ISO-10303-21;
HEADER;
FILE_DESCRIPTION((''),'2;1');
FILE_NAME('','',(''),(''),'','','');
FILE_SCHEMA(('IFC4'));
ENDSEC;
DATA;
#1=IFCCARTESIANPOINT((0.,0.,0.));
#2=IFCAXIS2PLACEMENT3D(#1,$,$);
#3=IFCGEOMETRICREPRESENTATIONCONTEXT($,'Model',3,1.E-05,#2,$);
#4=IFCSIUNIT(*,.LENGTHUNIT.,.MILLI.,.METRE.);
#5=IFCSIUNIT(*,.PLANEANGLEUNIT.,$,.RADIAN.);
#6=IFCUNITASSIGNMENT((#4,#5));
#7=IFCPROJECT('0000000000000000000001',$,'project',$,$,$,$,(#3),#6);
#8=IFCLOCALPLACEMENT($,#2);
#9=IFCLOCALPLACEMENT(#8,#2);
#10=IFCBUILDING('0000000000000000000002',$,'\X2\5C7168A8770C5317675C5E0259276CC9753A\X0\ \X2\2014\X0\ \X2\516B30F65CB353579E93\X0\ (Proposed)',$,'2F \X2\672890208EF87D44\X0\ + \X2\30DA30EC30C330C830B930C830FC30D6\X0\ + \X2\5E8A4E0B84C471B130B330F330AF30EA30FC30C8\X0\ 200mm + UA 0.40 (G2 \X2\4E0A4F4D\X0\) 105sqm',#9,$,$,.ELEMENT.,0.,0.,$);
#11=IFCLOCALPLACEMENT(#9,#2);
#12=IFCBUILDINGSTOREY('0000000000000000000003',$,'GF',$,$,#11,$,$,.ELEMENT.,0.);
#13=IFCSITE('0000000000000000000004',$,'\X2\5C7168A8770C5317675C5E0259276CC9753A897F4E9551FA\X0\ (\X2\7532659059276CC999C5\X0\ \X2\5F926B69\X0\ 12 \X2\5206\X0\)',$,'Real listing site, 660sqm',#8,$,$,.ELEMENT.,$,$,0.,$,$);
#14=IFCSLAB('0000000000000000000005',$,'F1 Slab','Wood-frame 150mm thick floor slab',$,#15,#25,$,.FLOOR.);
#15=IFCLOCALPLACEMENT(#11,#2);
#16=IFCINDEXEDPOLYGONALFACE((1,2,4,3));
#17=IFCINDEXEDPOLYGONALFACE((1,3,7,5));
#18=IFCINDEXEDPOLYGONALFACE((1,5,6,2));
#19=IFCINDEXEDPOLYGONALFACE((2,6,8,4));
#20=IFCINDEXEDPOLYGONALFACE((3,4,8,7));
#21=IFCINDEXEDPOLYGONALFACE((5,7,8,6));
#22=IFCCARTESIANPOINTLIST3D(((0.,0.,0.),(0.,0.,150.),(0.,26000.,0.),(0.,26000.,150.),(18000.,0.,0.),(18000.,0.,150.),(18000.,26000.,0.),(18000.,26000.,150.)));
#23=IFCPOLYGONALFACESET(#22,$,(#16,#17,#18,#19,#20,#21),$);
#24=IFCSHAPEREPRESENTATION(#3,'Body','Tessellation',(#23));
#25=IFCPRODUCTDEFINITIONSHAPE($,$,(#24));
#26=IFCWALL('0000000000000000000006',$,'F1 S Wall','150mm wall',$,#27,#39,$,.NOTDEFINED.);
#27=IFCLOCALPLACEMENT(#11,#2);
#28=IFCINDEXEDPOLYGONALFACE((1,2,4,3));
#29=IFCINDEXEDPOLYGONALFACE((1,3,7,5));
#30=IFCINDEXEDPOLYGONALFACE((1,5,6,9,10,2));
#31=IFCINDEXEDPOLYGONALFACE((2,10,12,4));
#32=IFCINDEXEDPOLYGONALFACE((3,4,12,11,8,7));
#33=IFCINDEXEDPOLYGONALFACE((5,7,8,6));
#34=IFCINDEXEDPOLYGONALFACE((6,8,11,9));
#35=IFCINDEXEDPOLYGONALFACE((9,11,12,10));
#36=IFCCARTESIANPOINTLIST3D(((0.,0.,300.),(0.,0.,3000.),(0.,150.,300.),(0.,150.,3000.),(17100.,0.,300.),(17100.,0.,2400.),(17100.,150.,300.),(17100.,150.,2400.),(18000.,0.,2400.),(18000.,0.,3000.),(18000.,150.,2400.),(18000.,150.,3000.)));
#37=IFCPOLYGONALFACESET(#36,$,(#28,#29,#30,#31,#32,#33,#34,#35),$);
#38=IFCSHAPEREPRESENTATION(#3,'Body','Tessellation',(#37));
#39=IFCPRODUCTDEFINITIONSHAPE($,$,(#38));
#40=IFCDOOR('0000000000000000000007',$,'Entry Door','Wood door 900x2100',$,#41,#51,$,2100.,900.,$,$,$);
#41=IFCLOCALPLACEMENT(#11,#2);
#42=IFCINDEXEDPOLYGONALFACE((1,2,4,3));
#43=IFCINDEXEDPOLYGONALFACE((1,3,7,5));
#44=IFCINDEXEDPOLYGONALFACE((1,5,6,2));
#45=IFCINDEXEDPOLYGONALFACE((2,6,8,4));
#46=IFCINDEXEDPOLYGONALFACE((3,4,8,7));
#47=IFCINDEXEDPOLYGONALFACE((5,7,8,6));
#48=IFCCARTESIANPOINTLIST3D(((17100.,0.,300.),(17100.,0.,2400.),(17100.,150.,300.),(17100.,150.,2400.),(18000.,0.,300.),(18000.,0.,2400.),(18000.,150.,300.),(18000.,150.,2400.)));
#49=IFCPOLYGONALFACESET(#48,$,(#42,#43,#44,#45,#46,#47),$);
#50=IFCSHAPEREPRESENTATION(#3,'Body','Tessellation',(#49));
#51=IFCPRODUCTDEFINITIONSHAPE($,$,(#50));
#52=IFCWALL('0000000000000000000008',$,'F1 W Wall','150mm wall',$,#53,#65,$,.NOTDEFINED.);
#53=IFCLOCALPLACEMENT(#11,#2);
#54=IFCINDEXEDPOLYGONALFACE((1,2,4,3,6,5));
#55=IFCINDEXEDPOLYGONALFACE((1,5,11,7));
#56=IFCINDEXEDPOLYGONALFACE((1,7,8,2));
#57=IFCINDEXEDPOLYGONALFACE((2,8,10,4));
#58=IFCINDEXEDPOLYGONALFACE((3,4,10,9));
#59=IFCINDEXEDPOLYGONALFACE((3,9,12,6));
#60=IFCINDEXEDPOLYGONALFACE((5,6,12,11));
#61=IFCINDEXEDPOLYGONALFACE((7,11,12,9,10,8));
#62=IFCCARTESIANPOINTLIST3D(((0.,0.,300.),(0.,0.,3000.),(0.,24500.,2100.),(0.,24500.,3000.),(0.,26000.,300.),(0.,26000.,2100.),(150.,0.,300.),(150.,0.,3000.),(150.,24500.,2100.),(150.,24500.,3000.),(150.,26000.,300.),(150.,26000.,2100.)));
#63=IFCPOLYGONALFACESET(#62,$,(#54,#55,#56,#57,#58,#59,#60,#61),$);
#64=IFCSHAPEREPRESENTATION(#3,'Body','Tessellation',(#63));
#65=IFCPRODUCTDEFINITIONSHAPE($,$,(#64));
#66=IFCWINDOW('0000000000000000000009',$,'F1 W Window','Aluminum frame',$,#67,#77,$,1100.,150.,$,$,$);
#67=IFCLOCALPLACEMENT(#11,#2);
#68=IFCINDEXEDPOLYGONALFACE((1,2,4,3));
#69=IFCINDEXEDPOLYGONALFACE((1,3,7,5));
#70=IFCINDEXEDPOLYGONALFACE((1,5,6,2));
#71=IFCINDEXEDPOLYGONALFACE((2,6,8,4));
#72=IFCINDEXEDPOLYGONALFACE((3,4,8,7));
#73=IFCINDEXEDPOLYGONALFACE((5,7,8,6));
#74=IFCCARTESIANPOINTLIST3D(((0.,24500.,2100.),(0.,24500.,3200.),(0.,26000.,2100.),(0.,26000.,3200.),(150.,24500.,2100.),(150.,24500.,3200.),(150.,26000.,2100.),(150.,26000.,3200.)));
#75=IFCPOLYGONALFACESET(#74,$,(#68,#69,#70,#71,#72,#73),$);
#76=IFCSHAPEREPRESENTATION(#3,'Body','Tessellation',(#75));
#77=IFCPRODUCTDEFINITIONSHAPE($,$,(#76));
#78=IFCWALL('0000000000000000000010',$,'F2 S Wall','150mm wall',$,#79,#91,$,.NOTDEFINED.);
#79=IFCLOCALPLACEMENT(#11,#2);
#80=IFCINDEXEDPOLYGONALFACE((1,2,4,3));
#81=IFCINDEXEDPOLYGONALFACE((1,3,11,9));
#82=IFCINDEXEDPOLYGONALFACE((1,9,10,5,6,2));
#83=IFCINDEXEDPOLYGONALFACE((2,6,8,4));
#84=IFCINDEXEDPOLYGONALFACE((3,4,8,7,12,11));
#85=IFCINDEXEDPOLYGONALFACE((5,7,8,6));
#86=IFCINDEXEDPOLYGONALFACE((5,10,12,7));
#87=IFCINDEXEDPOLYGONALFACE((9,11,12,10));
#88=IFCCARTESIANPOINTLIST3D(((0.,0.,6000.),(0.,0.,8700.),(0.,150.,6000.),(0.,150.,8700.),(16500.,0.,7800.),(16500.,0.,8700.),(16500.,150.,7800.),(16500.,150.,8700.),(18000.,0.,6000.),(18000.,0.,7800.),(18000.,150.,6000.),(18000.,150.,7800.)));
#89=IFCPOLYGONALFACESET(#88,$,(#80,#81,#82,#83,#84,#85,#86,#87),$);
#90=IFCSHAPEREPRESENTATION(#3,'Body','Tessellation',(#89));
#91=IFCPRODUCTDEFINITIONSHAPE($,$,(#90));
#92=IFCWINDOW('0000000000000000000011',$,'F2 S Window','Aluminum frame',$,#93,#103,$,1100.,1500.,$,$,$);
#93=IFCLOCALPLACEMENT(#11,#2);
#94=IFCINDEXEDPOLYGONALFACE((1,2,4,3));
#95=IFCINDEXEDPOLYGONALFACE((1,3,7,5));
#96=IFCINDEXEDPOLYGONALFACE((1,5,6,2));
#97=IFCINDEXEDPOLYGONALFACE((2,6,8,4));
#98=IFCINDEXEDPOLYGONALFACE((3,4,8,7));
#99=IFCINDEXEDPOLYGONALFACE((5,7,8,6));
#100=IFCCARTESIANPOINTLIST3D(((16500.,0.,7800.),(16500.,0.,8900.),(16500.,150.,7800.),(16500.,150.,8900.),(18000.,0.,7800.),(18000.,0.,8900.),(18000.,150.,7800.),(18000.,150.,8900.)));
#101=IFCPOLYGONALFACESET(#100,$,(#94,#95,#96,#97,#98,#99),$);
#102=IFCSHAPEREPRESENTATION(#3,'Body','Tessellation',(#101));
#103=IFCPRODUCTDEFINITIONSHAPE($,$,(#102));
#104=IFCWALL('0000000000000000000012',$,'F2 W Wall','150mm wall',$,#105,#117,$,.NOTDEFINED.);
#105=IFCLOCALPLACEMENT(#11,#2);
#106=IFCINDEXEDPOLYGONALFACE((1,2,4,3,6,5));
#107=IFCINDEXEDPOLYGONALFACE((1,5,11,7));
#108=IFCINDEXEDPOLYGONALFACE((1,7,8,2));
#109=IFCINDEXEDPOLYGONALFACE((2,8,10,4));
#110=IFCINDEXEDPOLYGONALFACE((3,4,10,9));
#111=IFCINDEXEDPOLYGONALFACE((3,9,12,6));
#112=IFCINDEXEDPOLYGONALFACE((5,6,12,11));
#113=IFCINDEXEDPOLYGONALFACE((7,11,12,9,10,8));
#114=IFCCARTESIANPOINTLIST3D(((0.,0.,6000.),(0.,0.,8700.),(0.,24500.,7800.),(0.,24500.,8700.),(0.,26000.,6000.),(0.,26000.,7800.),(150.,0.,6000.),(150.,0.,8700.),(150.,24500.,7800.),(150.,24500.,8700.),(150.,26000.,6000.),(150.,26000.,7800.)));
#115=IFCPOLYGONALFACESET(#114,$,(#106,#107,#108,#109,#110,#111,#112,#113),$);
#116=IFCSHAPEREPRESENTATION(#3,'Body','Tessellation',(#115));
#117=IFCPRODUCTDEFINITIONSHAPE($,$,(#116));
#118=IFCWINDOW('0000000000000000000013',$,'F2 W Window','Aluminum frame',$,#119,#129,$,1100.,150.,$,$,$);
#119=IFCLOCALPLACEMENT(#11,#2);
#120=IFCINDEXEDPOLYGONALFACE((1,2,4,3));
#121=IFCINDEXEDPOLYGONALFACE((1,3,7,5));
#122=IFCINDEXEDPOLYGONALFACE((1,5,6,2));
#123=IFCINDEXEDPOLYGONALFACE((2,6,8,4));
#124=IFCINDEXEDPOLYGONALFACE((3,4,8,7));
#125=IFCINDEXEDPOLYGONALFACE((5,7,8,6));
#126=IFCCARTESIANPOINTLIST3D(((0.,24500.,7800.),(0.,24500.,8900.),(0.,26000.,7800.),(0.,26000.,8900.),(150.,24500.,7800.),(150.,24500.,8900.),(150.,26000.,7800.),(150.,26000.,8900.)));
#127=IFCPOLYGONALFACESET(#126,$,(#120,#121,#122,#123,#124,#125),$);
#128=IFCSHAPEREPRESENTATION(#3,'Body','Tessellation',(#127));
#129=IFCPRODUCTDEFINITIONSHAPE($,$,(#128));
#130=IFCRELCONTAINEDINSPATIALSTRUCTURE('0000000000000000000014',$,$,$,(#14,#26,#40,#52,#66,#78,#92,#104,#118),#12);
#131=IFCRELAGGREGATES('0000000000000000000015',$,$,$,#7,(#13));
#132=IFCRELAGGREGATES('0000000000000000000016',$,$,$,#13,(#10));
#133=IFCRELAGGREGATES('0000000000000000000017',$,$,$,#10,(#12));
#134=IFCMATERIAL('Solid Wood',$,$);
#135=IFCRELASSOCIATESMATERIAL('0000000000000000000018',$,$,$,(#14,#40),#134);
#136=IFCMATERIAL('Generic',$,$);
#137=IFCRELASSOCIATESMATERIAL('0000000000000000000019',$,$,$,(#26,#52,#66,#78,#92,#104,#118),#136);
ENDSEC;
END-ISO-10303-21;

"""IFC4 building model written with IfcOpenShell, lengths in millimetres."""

from ifc_helpers import new_model, si_unit, frame, frame_2d, origin, place, context, project, spatial, rectangle, extrude, material, element, fill, save


model = new_model("IFC4")

# Units and contexts
model_context = context("Model", 3, precision=1e-05, world=origin())
ifc_project = project(units=[si_unit("LENGTHUNIT", "METRE", prefix="MILLI"), si_unit("PLANEANGLEUNIT", "RADIAN")], contexts=[model_context])

# Site, building, storey
site_placement = place(None, origin())
site = spatial("IfcSite", under=ifc_project, at=site_placement, Name="山梨県北杜市大泉町西井出 (甲斐大泉駅 徒歩 12 分)", ObjectType="Real listing site, 660sqm", CompositionType="ELEMENT", RefElevation=0.0)
building_placement = place(site_placement, origin())
building = spatial("IfcBuilding", under=site, at=building_placement, Name="山梨県北杜市大泉町 — 八ヶ岳南麓 (Proposed)", ObjectType="2F 木造軸組 + ペレットストーブ + 床下蓄熱コンクリート 200mm + UA 0.40 (G2 上位) 105sqm", CompositionType="ELEMENT", ElevationOfRefHeight=0.0, ElevationOfTerrain=0.0)
storey_placement = place(building_placement, origin())
storey = spatial("IfcBuildingStorey", under=building, at=storey_placement, Name="GF", CompositionType="ELEMENT", Elevation=0.0)

# Slab
ifc_material_1 = material(Name="Solid Wood")
slab_1_placement = place(storey_placement, origin())
element("IfcSlab", 1, at=slab_1_placement, inside=storey, material=ifc_material_1, Name="F1 Slab", Description="Wood-frame 150mm thick floor slab", PredefinedType="FLOOR", context=model_context, shape_type="SweptSolid", body=[
    extrude(rectangle(XDim=18000.0, YDim=26000.0, at=frame_2d((9000.0, 13000.0))), origin(), (0.0, 0.0, 1.0), 150.0),
])

# Shared definitions
ifc_material_2 = material(Name="Generic")

# Wall, opening, door
wall_1_placement = place(storey_placement, frame((0.0, 0.0, 150.0)))
wall_1 = element("IfcWall", 2, at=wall_1_placement, inside=storey, material=ifc_material_2, Name="F1 S Wall", Description="150mm wall", PredefinedType="NOTDEFINED", context=model_context, shape_type="SweptSolid", body=[
    extrude(rectangle(XDim=18000.0, YDim=150.0, at=frame_2d((9000.0, 75.0))), frame((0.0, 0.0, 150.0)), (0.0, 0.0, 1.0), 2700.0),
])
opening_1_placement = place(storey_placement, frame((8550.0, 0.0, 150.0)))
opening_1 = element("IfcOpeningElement", 3, at=opening_1_placement, cuts=wall_1, PredefinedType="NOTDEFINED", context=model_context, shape_type="SweptSolid", body=[
    extrude(rectangle(XDim=900.0, YDim=150.0, at=frame_2d((450.0, 75.0))), frame((8550.0, 0.0, 150.0)), (0.0, 0.0, 1.0), 2100.0),
])
door_placement = place(storey_placement, frame((8550.0, 0.0, 150.0)))
door = element("IfcDoor", 4, at=door_placement, inside=storey, material=ifc_material_1, Name="Entry Door", Description="Wood door 900x2100", OverallHeight=2100.0, OverallWidth=900.0, context=model_context, shape_type="SweptSolid", body=[
    extrude(rectangle(XDim=900.0, YDim=150.0, at=frame_2d((450.0, 75.0))), frame((8550.0, 0.0, 150.0)), (0.0, 0.0, 1.0), 2100.0),
])
fill(opening_1, door)

# Walls, openings, windows
wall_2_placement = place(storey_placement, frame((0.0, 0.0, 150.0)))
wall_2 = element("IfcWall", 5, at=wall_2_placement, inside=storey, material=ifc_material_2, Name="F1 W Wall", Description="150mm wall", PredefinedType="NOTDEFINED", context=model_context, shape_type="SweptSolid", body=[
    extrude(rectangle(XDim=150.0, YDim=26000.0, at=frame_2d((75.0, 13000.0))), frame((0.0, 0.0, 150.0)), (0.0, 0.0, 1.0), 2700.0),
])
opening_2_placement = place(storey_placement, frame((0.0, 12250.0, 1050.0)))
opening_2 = element("IfcOpeningElement", 6, at=opening_2_placement, cuts=wall_2, PredefinedType="NOTDEFINED", context=model_context, shape_type="SweptSolid", body=[
    extrude(rectangle(XDim=150.0, YDim=1500.0, at=frame_2d((75.0, 750.0))), frame((0.0, 12250.0, 1050.0)), (0.0, 0.0, 1.0), 1100.0),
])
window_1_placement = place(storey_placement, frame((0.0, 12250.0, 1050.0)))
window_1 = element("IfcWindow", 7, at=window_1_placement, inside=storey, material=ifc_material_2, Name="F1 W Window", Description="Aluminum frame", OverallHeight=1100.0, OverallWidth=150.0, context=model_context, shape_type="SweptSolid", body=[
    extrude(rectangle(XDim=150.0, YDim=1500.0, at=frame_2d((75.0, 750.0))), frame((0.0, 12250.0, 1050.0)), (0.0, 0.0, 1.0), 1100.0),
])
fill(opening_2, window_1)
wall_3_placement = place(storey_placement, frame((0.0, 0.0, 3000.0)))
wall_3 = element("IfcWall", 8, at=wall_3_placement, inside=storey, material=ifc_material_2, Name="F2 S Wall", Description="150mm wall", PredefinedType="NOTDEFINED", context=model_context, shape_type="SweptSolid", body=[
    extrude(rectangle(XDim=18000.0, YDim=150.0, at=frame_2d((9000.0, 75.0))), frame((0.0, 0.0, 3000.0)), (0.0, 0.0, 1.0), 2700.0),
])
opening_3_placement = place(storey_placement, frame((8250.0, 0.0, 3900.0)))
opening_3 = element("IfcOpeningElement", 9, at=opening_3_placement, cuts=wall_3, PredefinedType="NOTDEFINED", context=model_context, shape_type="SweptSolid", body=[
    extrude(rectangle(XDim=1500.0, YDim=150.0, at=frame_2d((750.0, 75.0))), frame((8250.0, 0.0, 3900.0)), (0.0, 0.0, 1.0), 1100.0),
])
window_2_placement = place(storey_placement, frame((8250.0, 0.0, 3900.0)))
window_2 = element("IfcWindow", 10, at=window_2_placement, inside=storey, material=ifc_material_2, Name="F2 S Window", Description="Aluminum frame", OverallHeight=1100.0, OverallWidth=1500.0, context=model_context, shape_type="SweptSolid", body=[
    extrude(rectangle(XDim=1500.0, YDim=150.0, at=frame_2d((750.0, 75.0))), frame((8250.0, 0.0, 3900.0)), (0.0, 0.0, 1.0), 1100.0),
])
fill(opening_3, window_2)
wall_4_placement = place(storey_placement, frame((0.0, 0.0, 3000.0)))
wall_4 = element("IfcWall", 11, at=wall_4_placement, inside=storey, material=ifc_material_2, Name="F2 W Wall", Description="150mm wall", PredefinedType="NOTDEFINED", context=model_context, shape_type="SweptSolid", body=[
    extrude(rectangle(XDim=150.0, YDim=26000.0, at=frame_2d((75.0, 13000.0))), frame((0.0, 0.0, 3000.0)), (0.0, 0.0, 1.0), 2700.0),
])
opening_4_placement = place(storey_placement, frame((0.0, 12250.0, 3900.0)))
opening_4 = element("IfcOpeningElement", 12, at=opening_4_placement, cuts=wall_4, PredefinedType="NOTDEFINED", context=model_context, shape_type="SweptSolid", body=[
    extrude(rectangle(XDim=150.0, YDim=1500.0, at=frame_2d((75.0, 750.0))), frame((0.0, 12250.0, 3900.0)), (0.0, 0.0, 1.0), 1100.0),
])
window_3_placement = place(storey_placement, frame((0.0, 12250.0, 3900.0)))
window_3 = element("IfcWindow", 13, at=window_3_placement, inside=storey, material=ifc_material_2, Name="F2 W Window", Description="Aluminum frame", OverallHeight=1100.0, OverallWidth=150.0, context=model_context, shape_type="SweptSolid", body=[
    extrude(rectangle(XDim=150.0, YDim=1500.0, at=frame_2d((75.0, 750.0))), frame((0.0, 12250.0, 3900.0)), (0.0, 0.0, 1.0), 1100.0),
])
fill(opening_4, window_3)

save(model, "model.ifc")
